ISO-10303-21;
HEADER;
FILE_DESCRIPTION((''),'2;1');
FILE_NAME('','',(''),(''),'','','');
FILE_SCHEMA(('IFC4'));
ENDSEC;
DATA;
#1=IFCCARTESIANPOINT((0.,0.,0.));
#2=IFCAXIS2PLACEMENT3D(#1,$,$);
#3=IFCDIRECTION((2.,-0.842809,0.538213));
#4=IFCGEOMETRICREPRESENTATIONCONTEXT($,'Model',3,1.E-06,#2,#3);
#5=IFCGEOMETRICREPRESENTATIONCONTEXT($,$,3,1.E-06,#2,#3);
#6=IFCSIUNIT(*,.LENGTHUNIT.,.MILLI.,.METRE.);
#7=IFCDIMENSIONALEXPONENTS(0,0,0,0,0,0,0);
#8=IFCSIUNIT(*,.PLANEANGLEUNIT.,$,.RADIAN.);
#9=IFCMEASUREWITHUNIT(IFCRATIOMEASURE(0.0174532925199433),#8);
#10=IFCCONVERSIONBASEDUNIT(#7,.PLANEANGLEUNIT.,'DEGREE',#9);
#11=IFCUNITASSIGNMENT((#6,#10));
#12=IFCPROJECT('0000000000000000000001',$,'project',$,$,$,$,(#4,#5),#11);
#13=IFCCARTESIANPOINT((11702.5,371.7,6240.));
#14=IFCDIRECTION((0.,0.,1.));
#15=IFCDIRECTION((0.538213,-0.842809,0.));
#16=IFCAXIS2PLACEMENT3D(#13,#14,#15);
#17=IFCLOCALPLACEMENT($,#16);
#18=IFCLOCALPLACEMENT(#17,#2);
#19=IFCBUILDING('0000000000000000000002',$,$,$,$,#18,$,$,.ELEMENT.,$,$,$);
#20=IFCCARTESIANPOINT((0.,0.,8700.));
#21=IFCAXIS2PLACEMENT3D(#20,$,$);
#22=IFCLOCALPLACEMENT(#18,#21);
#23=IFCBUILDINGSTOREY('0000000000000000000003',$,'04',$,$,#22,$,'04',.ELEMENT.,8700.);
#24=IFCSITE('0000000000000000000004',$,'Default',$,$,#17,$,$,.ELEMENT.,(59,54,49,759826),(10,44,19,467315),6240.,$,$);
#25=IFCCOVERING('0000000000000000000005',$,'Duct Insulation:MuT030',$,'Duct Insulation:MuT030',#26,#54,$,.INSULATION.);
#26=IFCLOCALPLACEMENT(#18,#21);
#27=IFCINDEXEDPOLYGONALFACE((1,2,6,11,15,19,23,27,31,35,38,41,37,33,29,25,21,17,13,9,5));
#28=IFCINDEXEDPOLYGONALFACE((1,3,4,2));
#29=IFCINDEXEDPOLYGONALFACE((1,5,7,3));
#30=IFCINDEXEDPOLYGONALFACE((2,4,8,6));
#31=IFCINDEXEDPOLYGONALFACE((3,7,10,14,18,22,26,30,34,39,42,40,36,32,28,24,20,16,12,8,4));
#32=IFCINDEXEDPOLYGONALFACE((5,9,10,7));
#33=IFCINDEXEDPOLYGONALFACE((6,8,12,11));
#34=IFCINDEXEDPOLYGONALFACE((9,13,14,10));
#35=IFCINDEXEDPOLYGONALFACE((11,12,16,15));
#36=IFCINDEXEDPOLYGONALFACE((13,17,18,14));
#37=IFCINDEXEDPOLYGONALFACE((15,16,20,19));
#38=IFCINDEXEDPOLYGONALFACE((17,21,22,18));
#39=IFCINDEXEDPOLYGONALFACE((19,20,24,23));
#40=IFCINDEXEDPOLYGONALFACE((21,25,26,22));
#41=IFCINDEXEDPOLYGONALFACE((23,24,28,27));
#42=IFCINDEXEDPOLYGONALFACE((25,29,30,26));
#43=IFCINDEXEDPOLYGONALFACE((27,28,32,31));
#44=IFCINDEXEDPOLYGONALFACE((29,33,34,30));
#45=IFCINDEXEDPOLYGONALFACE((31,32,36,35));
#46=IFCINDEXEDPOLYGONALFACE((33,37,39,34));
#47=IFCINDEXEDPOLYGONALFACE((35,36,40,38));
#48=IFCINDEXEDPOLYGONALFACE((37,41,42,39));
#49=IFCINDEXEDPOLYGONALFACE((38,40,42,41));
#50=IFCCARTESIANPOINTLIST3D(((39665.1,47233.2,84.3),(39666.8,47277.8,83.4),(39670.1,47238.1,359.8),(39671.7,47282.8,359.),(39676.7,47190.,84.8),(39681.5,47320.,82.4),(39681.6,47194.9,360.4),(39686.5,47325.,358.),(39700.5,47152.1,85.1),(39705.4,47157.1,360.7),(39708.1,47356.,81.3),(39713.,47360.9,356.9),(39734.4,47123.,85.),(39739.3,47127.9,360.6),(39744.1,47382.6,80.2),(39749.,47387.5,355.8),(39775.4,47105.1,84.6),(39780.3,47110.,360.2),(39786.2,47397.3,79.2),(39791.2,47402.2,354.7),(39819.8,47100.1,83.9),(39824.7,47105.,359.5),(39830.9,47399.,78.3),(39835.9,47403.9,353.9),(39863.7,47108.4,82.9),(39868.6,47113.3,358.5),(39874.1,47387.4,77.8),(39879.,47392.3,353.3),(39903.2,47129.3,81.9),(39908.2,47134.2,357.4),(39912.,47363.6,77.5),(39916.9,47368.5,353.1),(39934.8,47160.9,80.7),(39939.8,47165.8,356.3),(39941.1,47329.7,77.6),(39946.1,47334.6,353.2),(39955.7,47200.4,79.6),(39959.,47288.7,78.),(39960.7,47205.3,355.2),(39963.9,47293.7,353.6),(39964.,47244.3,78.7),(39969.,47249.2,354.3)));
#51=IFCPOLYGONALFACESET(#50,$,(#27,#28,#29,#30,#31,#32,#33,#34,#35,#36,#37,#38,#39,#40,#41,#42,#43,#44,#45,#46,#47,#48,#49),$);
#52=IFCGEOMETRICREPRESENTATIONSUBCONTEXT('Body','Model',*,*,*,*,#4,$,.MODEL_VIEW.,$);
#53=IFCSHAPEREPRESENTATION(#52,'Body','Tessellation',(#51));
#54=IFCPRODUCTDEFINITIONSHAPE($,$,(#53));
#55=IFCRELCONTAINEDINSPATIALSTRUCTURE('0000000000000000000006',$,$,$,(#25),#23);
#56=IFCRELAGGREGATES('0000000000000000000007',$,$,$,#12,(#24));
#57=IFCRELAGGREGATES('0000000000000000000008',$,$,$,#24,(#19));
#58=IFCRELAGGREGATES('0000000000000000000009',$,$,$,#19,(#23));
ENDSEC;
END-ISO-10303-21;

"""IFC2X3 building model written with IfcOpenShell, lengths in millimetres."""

from ifc_helpers import new_model, entity, si_unit, converted_unit, direction, frame, origin, origin_2d_with_axis, place, context, subcontext, project, spatial, circle, extrude, element, save


model = new_model("IFC2X3")

# Units and contexts
model_context = context("Model", 3, precision=1e-06, world=origin(), true_north=direction((2.0, -0.842809, 0.538213)))
context_of_model = context(None, 3, precision=1e-06, world=origin(), true_north=direction((2.0, -0.842809, 0.538213)))
body_context = subcontext(model_context, "Body", "Model", "MODEL_VIEW")
ifc_project = project(units=[si_unit("LENGTHUNIT", "METRE", prefix="MILLI"), converted_unit("PLANEANGLEUNIT", "DEGREE", entity("IfcRatioMeasure", 0.0174532925199433), si_unit("PLANEANGLEUNIT", "RADIAN"), dimensions=[0, 0, 0, 0, 0, 0, 0])], contexts=[model_context, context_of_model])

# Site, building, storey
site_placement = place(None, frame((11702.5, 371.7, 6240.0), z_axis=(0.0, 0.0, 1.0), x_axis=(0.538213, -0.842809, 0.0)))
site = spatial("IfcSite", under=ifc_project, at=site_placement, Name="Default", CompositionType="ELEMENT", RefLatitude=(59, 54, 49, 759826), RefLongitude=(10, 44, 19, 467315), RefElevation=6240.0)
building_placement = place(site_placement, origin())
building = spatial("IfcBuilding", under=site, at=building_placement, CompositionType="ELEMENT")
storey_placement = place(building_placement, frame((0.0, 0.0, 8700.0)))
storey = spatial("IfcBuildingStorey", under=building, at=storey_placement, Name="04", LongName="04", CompositionType="ELEMENT", Elevation=8700.0)

# Covering
covering_1_placement = place(building_placement, frame((0.0, 0.0, 8700.0)))
element("IfcCovering", 1, at=covering_1_placement, inside=storey, Name="Duct Insulation:MuT030", ObjectType="Duct Insulation:MuT030", PredefinedType="INSULATION", context=body_context, shape_type="SweptSolid", body=[
    extrude(circle(Radius=150.0, at=origin_2d_with_axis()), frame((39814.2, 47249.9, 81.3), z_axis=(0.017894, 0.017894, 0.99968), x_axis=(-0.707107, 0.707107, 0.0)), (0.0, 0.0, 1.0), 275.7),
])

save(model, "model.ifc")
